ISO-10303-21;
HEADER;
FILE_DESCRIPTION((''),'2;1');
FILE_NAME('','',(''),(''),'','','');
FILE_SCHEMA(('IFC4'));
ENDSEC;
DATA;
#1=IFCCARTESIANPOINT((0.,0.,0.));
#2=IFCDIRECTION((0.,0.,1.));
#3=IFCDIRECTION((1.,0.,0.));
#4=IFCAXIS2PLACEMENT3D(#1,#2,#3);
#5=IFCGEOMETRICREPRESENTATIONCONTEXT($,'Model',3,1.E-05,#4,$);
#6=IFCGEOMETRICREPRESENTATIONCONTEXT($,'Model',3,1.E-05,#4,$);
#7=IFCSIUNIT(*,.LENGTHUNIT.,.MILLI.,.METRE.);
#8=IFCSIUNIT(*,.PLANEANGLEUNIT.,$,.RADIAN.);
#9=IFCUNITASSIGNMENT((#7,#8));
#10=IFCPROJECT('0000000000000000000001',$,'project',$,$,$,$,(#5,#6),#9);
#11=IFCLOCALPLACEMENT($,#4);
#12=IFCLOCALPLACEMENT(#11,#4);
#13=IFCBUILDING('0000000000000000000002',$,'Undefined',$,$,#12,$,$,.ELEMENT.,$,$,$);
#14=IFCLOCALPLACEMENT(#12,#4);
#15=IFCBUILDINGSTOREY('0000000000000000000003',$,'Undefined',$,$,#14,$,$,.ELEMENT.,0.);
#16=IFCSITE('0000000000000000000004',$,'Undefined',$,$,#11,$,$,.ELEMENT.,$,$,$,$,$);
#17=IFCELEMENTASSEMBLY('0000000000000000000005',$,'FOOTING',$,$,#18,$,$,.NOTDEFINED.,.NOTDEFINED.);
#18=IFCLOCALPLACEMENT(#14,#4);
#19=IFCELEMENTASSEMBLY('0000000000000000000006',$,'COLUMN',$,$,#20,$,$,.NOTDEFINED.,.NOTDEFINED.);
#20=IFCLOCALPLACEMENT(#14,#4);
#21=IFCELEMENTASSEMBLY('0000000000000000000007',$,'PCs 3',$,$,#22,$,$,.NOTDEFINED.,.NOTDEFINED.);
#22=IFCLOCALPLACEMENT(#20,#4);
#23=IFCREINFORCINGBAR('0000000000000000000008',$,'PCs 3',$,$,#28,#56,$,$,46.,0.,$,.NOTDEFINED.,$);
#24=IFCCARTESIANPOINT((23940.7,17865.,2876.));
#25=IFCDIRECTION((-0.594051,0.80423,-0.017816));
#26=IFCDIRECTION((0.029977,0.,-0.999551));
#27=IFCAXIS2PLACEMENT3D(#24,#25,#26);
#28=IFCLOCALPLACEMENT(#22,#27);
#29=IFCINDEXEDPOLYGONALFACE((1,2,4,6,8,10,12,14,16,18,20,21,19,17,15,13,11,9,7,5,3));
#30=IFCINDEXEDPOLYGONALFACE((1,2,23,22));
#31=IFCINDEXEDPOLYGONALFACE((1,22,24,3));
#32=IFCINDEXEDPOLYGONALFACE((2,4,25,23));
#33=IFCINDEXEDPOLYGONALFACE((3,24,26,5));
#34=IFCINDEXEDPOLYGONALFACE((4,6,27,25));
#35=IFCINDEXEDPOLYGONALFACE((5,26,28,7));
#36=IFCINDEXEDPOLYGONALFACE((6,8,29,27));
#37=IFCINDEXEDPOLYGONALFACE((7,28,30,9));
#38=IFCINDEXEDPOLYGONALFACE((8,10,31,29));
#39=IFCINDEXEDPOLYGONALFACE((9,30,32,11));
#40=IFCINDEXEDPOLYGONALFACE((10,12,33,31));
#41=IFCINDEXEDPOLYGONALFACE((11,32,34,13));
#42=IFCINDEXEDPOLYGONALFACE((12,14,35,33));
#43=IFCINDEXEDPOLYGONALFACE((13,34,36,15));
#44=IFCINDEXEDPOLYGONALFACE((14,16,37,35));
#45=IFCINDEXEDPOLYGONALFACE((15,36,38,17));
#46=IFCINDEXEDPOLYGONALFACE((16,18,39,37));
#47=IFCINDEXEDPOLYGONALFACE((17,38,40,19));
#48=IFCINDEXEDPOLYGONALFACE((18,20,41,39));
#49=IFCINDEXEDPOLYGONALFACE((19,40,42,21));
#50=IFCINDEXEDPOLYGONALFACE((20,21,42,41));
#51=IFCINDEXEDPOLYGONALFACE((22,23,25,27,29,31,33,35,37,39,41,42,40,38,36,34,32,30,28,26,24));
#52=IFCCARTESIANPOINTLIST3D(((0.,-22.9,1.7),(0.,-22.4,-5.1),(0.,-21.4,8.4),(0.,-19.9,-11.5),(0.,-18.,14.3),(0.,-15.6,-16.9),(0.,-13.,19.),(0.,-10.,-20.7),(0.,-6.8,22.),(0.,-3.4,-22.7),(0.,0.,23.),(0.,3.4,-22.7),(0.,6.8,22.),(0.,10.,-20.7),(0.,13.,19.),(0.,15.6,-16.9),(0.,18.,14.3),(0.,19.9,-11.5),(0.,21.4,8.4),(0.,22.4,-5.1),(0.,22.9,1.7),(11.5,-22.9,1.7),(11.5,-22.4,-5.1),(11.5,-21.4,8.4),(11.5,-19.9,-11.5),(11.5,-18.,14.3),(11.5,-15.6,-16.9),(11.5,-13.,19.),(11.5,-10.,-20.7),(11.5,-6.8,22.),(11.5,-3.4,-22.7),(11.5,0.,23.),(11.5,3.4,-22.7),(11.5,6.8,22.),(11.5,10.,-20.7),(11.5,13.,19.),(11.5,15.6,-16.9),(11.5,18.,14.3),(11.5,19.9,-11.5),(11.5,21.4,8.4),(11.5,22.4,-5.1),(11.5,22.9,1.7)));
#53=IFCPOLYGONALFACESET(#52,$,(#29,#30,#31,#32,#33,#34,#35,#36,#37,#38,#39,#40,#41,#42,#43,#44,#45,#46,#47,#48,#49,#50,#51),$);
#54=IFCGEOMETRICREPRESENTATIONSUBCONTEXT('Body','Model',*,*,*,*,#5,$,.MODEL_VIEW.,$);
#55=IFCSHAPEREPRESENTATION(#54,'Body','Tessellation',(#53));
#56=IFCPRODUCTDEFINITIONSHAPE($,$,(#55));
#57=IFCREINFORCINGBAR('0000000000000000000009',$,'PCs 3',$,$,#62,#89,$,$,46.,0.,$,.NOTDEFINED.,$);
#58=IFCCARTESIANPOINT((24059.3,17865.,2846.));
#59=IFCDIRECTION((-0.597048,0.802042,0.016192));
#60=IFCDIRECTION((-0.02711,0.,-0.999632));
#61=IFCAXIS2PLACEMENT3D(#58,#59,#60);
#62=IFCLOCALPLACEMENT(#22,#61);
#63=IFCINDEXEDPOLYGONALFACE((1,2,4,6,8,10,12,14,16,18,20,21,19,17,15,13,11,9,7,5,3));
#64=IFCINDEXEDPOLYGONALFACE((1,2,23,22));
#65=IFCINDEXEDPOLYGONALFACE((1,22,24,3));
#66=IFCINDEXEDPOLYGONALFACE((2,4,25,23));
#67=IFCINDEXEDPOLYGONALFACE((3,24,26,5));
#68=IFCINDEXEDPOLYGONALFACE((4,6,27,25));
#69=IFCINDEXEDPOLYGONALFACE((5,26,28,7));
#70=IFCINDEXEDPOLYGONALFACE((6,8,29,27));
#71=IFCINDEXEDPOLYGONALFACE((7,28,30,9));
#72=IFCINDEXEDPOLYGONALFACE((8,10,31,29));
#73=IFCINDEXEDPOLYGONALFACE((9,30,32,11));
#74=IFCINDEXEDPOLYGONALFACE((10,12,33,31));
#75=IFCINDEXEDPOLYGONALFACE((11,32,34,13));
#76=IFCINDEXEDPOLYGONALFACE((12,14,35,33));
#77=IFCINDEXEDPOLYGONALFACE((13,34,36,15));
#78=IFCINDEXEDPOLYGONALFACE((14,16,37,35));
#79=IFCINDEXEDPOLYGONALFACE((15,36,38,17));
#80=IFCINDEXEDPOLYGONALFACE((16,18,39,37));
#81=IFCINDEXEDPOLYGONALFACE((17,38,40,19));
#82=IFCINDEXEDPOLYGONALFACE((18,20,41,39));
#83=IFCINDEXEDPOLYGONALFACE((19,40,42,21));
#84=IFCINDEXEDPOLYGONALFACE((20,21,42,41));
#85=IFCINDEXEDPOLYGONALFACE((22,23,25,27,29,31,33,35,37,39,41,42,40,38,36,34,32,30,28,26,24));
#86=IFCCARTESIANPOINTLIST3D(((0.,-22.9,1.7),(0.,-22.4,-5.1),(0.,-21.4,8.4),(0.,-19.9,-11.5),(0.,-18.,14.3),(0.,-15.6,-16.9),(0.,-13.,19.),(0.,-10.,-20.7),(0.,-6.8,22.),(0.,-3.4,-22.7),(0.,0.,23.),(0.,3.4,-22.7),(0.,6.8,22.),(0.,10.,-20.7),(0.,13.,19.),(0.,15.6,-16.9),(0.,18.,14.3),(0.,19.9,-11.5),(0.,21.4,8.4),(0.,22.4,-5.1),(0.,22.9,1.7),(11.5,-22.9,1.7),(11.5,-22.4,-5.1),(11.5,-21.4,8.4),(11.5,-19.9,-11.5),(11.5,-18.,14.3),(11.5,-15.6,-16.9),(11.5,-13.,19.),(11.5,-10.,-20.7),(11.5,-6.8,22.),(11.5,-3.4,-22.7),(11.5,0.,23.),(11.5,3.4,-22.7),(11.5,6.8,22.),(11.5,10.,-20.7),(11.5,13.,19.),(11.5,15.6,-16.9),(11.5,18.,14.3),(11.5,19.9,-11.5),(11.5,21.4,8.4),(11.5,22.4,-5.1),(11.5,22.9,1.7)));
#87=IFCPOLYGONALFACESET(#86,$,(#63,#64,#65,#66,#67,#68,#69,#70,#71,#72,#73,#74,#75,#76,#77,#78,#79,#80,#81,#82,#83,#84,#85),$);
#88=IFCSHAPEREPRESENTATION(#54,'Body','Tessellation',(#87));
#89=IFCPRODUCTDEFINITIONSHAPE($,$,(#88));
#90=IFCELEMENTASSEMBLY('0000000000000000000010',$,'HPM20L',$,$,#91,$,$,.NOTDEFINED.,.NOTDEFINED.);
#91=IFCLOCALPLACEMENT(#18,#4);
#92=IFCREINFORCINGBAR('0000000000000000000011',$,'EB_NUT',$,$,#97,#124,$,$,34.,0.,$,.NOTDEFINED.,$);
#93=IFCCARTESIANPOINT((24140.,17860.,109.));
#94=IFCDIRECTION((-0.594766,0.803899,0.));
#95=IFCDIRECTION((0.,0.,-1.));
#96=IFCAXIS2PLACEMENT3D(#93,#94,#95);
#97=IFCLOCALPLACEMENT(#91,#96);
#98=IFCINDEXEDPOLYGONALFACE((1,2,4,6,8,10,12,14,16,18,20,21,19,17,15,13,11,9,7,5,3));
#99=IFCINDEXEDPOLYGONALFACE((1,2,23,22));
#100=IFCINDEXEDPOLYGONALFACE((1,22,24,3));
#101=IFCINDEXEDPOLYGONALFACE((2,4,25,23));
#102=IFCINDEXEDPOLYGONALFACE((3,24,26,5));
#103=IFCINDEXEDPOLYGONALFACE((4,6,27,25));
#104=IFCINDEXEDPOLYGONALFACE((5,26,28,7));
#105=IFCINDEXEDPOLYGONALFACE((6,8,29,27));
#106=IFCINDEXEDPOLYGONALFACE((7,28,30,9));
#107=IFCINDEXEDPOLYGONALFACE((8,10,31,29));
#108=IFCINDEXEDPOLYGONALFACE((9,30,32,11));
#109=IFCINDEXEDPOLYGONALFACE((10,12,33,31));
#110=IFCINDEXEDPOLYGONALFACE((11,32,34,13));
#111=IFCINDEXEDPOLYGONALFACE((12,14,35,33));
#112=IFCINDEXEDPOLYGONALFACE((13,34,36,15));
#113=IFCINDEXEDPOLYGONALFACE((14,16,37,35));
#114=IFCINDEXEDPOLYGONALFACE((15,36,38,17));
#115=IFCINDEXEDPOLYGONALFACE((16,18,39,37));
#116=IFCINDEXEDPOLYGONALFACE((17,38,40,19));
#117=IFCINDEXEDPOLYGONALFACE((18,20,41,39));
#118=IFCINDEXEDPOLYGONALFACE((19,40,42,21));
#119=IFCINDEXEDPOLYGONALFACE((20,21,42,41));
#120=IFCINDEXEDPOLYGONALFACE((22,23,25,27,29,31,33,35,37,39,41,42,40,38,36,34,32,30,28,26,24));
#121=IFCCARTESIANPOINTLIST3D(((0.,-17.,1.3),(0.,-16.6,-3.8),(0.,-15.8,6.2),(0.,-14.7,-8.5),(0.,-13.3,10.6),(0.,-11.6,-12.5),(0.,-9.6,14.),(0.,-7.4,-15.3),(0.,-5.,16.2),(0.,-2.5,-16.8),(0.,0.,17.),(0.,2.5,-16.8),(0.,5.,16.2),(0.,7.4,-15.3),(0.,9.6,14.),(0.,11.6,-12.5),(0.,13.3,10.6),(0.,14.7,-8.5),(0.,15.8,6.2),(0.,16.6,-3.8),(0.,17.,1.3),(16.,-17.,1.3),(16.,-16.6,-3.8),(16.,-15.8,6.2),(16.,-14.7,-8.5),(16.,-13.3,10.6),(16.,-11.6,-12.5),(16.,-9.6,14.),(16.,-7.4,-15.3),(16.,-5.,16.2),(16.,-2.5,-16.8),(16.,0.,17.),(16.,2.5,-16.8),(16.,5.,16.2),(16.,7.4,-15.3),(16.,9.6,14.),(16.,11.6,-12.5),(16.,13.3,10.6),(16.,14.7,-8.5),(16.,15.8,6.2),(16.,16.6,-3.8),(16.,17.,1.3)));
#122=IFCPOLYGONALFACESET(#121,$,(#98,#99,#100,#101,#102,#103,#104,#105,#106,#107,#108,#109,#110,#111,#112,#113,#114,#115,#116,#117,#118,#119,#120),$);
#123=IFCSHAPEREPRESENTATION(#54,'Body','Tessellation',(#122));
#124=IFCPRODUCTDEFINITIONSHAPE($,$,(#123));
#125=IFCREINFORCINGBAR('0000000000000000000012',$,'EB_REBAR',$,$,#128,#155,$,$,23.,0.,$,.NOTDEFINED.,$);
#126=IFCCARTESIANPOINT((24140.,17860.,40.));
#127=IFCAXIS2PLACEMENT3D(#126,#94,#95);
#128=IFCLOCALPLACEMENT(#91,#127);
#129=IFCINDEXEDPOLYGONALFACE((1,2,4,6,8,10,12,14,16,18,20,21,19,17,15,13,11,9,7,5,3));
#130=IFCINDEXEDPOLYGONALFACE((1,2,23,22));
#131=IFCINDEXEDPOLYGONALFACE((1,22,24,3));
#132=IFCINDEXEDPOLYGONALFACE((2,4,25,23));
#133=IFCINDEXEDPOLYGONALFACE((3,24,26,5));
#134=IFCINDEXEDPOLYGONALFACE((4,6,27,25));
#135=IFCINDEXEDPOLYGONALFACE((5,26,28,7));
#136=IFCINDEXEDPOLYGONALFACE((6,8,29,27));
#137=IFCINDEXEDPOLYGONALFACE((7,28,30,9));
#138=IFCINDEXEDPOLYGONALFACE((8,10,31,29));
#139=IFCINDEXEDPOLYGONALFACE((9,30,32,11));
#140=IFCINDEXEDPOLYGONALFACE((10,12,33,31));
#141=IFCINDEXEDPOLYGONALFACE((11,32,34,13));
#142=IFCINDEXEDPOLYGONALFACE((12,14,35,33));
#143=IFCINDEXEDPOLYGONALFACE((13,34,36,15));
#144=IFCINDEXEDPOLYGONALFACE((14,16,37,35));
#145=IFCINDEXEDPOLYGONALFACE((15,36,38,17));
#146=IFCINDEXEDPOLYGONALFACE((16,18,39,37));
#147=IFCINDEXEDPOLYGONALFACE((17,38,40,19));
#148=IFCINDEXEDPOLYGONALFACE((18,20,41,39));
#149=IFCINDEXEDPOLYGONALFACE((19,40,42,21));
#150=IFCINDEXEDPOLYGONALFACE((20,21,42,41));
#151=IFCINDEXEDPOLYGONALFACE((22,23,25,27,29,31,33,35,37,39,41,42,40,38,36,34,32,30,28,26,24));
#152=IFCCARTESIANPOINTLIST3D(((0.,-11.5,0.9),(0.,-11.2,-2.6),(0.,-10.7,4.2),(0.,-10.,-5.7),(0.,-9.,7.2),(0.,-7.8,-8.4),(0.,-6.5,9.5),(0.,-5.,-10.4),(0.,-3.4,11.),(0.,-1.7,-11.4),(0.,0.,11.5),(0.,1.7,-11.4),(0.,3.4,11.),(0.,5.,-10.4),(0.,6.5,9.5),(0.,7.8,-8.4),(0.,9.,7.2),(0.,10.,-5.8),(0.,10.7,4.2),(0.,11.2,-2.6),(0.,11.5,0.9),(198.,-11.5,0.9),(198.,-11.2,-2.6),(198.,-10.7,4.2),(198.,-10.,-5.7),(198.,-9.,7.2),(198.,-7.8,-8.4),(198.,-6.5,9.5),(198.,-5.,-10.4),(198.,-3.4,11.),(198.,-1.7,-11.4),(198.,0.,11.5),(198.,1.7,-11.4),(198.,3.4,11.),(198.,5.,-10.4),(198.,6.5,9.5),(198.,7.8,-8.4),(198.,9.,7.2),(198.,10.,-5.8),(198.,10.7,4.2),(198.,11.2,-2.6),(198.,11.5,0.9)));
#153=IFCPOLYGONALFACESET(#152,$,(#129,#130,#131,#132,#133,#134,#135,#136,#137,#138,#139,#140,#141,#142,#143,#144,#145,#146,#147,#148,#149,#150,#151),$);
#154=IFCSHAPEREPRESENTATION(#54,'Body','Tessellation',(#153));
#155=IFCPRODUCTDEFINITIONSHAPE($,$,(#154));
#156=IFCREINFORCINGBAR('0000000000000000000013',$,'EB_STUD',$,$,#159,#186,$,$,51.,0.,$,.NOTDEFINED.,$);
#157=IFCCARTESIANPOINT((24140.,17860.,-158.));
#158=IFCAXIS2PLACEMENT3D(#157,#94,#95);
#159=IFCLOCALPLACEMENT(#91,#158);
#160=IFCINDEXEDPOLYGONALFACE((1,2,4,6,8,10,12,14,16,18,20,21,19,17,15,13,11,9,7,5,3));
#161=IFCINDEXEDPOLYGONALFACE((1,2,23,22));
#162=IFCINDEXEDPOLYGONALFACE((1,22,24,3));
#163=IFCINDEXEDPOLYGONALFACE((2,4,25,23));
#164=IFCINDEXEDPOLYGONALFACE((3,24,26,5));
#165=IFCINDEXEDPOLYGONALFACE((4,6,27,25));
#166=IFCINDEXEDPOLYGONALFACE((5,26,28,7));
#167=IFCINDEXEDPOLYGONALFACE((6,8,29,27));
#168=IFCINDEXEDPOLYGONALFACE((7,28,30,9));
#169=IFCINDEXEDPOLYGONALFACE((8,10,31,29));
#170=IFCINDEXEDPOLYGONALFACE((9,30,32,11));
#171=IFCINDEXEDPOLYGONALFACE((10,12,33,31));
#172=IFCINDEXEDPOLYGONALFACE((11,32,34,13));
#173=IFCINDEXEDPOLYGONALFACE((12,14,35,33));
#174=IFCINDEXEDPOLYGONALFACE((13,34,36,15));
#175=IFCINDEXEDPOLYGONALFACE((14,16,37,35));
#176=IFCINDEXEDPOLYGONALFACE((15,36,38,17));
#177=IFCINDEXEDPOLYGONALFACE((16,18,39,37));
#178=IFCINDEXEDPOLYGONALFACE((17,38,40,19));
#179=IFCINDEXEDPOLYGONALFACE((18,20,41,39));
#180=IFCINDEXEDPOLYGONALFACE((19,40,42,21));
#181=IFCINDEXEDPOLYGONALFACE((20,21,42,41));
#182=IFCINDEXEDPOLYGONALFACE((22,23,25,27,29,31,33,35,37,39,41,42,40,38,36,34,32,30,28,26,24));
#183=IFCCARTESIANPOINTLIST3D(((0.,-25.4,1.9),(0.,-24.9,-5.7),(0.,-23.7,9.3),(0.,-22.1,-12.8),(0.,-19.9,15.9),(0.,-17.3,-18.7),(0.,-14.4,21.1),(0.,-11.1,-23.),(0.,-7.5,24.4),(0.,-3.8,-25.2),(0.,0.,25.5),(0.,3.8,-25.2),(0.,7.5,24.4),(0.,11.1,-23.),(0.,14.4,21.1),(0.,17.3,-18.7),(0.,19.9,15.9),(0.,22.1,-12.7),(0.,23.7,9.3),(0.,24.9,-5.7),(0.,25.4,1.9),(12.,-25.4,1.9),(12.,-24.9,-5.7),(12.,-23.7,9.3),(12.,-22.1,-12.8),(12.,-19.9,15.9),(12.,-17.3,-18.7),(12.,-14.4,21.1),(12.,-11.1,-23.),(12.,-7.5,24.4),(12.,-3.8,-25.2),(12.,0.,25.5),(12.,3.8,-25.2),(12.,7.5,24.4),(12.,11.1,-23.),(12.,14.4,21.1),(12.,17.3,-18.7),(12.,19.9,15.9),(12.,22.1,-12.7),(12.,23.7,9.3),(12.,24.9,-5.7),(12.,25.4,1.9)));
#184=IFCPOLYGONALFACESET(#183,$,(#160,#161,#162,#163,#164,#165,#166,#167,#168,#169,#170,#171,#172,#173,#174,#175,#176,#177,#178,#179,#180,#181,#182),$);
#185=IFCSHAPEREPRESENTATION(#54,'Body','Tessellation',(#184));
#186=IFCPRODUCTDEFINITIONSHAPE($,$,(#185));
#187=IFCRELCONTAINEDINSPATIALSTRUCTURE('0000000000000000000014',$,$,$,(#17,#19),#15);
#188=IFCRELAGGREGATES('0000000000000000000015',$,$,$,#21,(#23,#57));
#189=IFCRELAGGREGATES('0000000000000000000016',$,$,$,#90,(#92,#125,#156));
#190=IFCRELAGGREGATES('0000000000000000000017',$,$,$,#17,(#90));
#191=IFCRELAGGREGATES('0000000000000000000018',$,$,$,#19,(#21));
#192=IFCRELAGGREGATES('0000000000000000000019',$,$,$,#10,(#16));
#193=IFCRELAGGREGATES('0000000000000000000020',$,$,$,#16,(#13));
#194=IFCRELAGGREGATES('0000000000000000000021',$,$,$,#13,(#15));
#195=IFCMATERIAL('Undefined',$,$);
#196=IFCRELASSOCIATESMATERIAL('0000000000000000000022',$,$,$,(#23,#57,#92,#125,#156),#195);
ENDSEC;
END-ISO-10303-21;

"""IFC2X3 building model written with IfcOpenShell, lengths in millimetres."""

from ifc_helpers import new_model, entity, si_unit, frame, origin_with_axes, place, context, subcontext, project, spatial, source, transform, mapped, material, element, aggregate, save


model = new_model("IFC2X3")

# Units and contexts
model_context_1 = context("Model", 3, precision=1e-05, world=origin_with_axes())
model_context_2 = context("Model", 3, precision=1e-05, world=origin_with_axes())
body_context = subcontext(model_context_1, "Body", "Model", "MODEL_VIEW")
ifc_project = project(units=[si_unit("LENGTHUNIT", "METRE", prefix="MILLI"), si_unit("PLANEANGLEUNIT", "RADIAN")], contexts=[model_context_1, model_context_2])

# Site, building, storey
site_placement = place(None, origin_with_axes())
site = spatial("IfcSite", under=ifc_project, at=site_placement, Name="Undefined", CompositionType="ELEMENT")
building_placement = place(site_placement, origin_with_axes())
building = spatial("IfcBuilding", under=site, at=building_placement, Name="Undefined", CompositionType="ELEMENT")
storey_placement = place(building_placement, origin_with_axes())
storey = spatial("IfcBuildingStorey", under=building, at=storey_placement, Name="Undefined", CompositionType="ELEMENT", Elevation=0.0)

# Element assembly
assembly_1_placement = place(storey_placement, origin_with_axes())
assembly_1 = element("IfcElementAssembly", 1, at=assembly_1_placement, inside=storey, Name="FOOTING", AssemblyPlace="NOTDEFINED", PredefinedType="NOTDEFINED")

# Element assemblies, reinforcing bars
assembly_2_placement = place(storey_placement, origin_with_axes())
assembly_2 = element("IfcElementAssembly", 2, at=assembly_2_placement, inside=storey, Name="COLUMN", AssemblyPlace="NOTDEFINED", PredefinedType="NOTDEFINED")
assembly_3_placement = place(assembly_2_placement, origin_with_axes())
assembly_3 = element("IfcElementAssembly", 3, at=assembly_3_placement, Name="PCs 3", AssemblyPlace="NOTDEFINED", PredefinedType="NOTDEFINED")
ifc_material_1 = material(Name="Undefined")
shared_shape_1 = source(origin_with_axes(), body_context, "Body", "AdvancedSweptSolid", [
    entity("IfcSweptDiskSolid", entity("IfcTrimmedCurve", entity("IfcLine", entity("IfcCartesianPoint", [0.0, 0.0, 0.0]), entity("IfcVector", entity("IfcDirection", [1.0, 0.0, 0.0]), 1.0)), [entity("IfcParameterValue", 0.0)], [entity("IfcParameterValue", 11.5)], True, "PARAMETER"), 23.0, None, 0.0, 11.5),
])
reinforcing_bar_1_placement = place(assembly_3_placement, frame((23940.7, 17865.0, 2876.0), z_axis=(-0.594051, 0.80423, -0.017816), x_axis=(0.029977, 0.0, -0.999551)))
reinforcing_bar_1 = element("IfcReinforcingBar", 4, at=reinforcing_bar_1_placement, material=ifc_material_1, Name="PCs 3", BarRole="NOTDEFINED", CrossSectionArea=0.0, NominalDiameter=46.0, context=body_context, shape_type="MappedRepresentation", body=[
    mapped(shared_shape_1, transform((0.0, 0.0, 0.0))),
])
shared_shape_2 = source(origin_with_axes(), body_context, "Body", "AdvancedSweptSolid", [
    entity("IfcSweptDiskSolid", entity("IfcTrimmedCurve", entity("IfcLine", entity("IfcCartesianPoint", [0.0, 0.0, 0.0]), entity("IfcVector", entity("IfcDirection", [1.0, 0.0, 0.0]), 1.0)), [entity("IfcParameterValue", 0.0)], [entity("IfcParameterValue", 11.5)], True, "PARAMETER"), 23.0, None, 0.0, 11.5),
])
reinforcing_bar_2_placement = place(assembly_3_placement, frame((24059.3, 17865.0, 2846.0), z_axis=(-0.597048, 0.802042, 0.016192), x_axis=(-0.02711, 0.0, -0.999632)))
reinforcing_bar_2 = element("IfcReinforcingBar", 5, at=reinforcing_bar_2_placement, material=ifc_material_1, Name="PCs 3", BarRole="NOTDEFINED", CrossSectionArea=0.0, NominalDiameter=46.0, context=body_context, shape_type="MappedRepresentation", body=[
    mapped(shared_shape_2, transform((0.0, 0.0, 0.0))),
])
aggregate(assembly_3, [reinforcing_bar_1, reinforcing_bar_2])

# Element assembly, reinforcing bars
assembly_4_placement = place(assembly_1_placement, origin_with_axes())
assembly_4 = element("IfcElementAssembly", 6, at=assembly_4_placement, Name="HPM20L", AssemblyPlace="NOTDEFINED", PredefinedType="NOTDEFINED")
shared_shape_3 = source(origin_with_axes(), body_context, "Body", "AdvancedSweptSolid", [
    entity("IfcSweptDiskSolid", entity("IfcTrimmedCurve", entity("IfcLine", entity("IfcCartesianPoint", [0.0, 0.0, 0.0]), entity("IfcVector", entity("IfcDirection", [1.0, 0.0, 0.0]), 1.0)), [entity("IfcParameterValue", 0.0)], [entity("IfcParameterValue", 16.0)], True, "PARAMETER"), 17.0, None, 0.0, 16.0),
])
reinforcing_bar_3_placement = place(assembly_4_placement, frame((24140.0, 17860.0, 109.0), z_axis=(-0.594766, 0.803899, 0.0), x_axis=(0.0, 0.0, -1.0)))
reinforcing_bar_3 = element("IfcReinforcingBar", 7, at=reinforcing_bar_3_placement, material=ifc_material_1, Name="EB_NUT", BarRole="NOTDEFINED", CrossSectionArea=0.0, NominalDiameter=34.0, context=body_context, shape_type="MappedRepresentation", body=[
    mapped(shared_shape_3, transform((0.0, 0.0, 0.0))),
])
shared_shape_4 = source(origin_with_axes(), body_context, "Body", "AdvancedSweptSolid", [
    entity("IfcSweptDiskSolid", entity("IfcTrimmedCurve", entity("IfcLine", entity("IfcCartesianPoint", [0.0, 0.0, 0.0]), entity("IfcVector", entity("IfcDirection", [1.0, 0.0, 0.0]), 1.0)), [entity("IfcParameterValue", 0.0)], [entity("IfcParameterValue", 198.0)], True, "PARAMETER"), 11.5, None, 0.0, 198.0),
])
reinforcing_bar_4_placement = place(assembly_4_placement, frame((24140.0, 17860.0, 40.0), z_axis=(-0.594766, 0.803899, 0.0), x_axis=(0.0, 0.0, -1.0)))
reinforcing_bar_4 = element("IfcReinforcingBar", 8, at=reinforcing_bar_4_placement, material=ifc_material_1, Name="EB_REBAR", BarRole="NOTDEFINED", CrossSectionArea=0.0, NominalDiameter=23.0, context=body_context, shape_type="MappedRepresentation", body=[
    mapped(shared_shape_4, transform((0.0, 0.0, 0.0))),
])
shared_shape_5 = source(origin_with_axes(), body_context, "Body", "AdvancedSweptSolid", [
    entity("IfcSweptDiskSolid", entity("IfcTrimmedCurve", entity("IfcLine", entity("IfcCartesianPoint", [0.0, 0.0, 0.0]), entity("IfcVector", entity("IfcDirection", [1.0, 0.0, 0.0]), 1.0)), [entity("IfcParameterValue", 0.0)], [entity("IfcParameterValue", 12.0)], True, "PARAMETER"), 25.5, None, 0.0, 12.0),
])
reinforcing_bar_5_placement = place(assembly_4_placement, frame((24140.0, 17860.0, -158.0), z_axis=(-0.594766, 0.803899, 0.0), x_axis=(0.0, 0.0, -1.0)))
reinforcing_bar_5 = element("IfcReinforcingBar", 9, at=reinforcing_bar_5_placement, material=ifc_material_1, Name="EB_STUD", BarRole="NOTDEFINED", CrossSectionArea=0.0, NominalDiameter=51.0, context=body_context, shape_type="MappedRepresentation", body=[
    mapped(shared_shape_5, transform((0.0, 0.0, 0.0))),
])
aggregate(assembly_4, [reinforcing_bar_3, reinforcing_bar_4, reinforcing_bar_5])

aggregate(assembly_1, [assembly_4])

aggregate(assembly_2, [assembly_3])

save(model, "model.ifc")
